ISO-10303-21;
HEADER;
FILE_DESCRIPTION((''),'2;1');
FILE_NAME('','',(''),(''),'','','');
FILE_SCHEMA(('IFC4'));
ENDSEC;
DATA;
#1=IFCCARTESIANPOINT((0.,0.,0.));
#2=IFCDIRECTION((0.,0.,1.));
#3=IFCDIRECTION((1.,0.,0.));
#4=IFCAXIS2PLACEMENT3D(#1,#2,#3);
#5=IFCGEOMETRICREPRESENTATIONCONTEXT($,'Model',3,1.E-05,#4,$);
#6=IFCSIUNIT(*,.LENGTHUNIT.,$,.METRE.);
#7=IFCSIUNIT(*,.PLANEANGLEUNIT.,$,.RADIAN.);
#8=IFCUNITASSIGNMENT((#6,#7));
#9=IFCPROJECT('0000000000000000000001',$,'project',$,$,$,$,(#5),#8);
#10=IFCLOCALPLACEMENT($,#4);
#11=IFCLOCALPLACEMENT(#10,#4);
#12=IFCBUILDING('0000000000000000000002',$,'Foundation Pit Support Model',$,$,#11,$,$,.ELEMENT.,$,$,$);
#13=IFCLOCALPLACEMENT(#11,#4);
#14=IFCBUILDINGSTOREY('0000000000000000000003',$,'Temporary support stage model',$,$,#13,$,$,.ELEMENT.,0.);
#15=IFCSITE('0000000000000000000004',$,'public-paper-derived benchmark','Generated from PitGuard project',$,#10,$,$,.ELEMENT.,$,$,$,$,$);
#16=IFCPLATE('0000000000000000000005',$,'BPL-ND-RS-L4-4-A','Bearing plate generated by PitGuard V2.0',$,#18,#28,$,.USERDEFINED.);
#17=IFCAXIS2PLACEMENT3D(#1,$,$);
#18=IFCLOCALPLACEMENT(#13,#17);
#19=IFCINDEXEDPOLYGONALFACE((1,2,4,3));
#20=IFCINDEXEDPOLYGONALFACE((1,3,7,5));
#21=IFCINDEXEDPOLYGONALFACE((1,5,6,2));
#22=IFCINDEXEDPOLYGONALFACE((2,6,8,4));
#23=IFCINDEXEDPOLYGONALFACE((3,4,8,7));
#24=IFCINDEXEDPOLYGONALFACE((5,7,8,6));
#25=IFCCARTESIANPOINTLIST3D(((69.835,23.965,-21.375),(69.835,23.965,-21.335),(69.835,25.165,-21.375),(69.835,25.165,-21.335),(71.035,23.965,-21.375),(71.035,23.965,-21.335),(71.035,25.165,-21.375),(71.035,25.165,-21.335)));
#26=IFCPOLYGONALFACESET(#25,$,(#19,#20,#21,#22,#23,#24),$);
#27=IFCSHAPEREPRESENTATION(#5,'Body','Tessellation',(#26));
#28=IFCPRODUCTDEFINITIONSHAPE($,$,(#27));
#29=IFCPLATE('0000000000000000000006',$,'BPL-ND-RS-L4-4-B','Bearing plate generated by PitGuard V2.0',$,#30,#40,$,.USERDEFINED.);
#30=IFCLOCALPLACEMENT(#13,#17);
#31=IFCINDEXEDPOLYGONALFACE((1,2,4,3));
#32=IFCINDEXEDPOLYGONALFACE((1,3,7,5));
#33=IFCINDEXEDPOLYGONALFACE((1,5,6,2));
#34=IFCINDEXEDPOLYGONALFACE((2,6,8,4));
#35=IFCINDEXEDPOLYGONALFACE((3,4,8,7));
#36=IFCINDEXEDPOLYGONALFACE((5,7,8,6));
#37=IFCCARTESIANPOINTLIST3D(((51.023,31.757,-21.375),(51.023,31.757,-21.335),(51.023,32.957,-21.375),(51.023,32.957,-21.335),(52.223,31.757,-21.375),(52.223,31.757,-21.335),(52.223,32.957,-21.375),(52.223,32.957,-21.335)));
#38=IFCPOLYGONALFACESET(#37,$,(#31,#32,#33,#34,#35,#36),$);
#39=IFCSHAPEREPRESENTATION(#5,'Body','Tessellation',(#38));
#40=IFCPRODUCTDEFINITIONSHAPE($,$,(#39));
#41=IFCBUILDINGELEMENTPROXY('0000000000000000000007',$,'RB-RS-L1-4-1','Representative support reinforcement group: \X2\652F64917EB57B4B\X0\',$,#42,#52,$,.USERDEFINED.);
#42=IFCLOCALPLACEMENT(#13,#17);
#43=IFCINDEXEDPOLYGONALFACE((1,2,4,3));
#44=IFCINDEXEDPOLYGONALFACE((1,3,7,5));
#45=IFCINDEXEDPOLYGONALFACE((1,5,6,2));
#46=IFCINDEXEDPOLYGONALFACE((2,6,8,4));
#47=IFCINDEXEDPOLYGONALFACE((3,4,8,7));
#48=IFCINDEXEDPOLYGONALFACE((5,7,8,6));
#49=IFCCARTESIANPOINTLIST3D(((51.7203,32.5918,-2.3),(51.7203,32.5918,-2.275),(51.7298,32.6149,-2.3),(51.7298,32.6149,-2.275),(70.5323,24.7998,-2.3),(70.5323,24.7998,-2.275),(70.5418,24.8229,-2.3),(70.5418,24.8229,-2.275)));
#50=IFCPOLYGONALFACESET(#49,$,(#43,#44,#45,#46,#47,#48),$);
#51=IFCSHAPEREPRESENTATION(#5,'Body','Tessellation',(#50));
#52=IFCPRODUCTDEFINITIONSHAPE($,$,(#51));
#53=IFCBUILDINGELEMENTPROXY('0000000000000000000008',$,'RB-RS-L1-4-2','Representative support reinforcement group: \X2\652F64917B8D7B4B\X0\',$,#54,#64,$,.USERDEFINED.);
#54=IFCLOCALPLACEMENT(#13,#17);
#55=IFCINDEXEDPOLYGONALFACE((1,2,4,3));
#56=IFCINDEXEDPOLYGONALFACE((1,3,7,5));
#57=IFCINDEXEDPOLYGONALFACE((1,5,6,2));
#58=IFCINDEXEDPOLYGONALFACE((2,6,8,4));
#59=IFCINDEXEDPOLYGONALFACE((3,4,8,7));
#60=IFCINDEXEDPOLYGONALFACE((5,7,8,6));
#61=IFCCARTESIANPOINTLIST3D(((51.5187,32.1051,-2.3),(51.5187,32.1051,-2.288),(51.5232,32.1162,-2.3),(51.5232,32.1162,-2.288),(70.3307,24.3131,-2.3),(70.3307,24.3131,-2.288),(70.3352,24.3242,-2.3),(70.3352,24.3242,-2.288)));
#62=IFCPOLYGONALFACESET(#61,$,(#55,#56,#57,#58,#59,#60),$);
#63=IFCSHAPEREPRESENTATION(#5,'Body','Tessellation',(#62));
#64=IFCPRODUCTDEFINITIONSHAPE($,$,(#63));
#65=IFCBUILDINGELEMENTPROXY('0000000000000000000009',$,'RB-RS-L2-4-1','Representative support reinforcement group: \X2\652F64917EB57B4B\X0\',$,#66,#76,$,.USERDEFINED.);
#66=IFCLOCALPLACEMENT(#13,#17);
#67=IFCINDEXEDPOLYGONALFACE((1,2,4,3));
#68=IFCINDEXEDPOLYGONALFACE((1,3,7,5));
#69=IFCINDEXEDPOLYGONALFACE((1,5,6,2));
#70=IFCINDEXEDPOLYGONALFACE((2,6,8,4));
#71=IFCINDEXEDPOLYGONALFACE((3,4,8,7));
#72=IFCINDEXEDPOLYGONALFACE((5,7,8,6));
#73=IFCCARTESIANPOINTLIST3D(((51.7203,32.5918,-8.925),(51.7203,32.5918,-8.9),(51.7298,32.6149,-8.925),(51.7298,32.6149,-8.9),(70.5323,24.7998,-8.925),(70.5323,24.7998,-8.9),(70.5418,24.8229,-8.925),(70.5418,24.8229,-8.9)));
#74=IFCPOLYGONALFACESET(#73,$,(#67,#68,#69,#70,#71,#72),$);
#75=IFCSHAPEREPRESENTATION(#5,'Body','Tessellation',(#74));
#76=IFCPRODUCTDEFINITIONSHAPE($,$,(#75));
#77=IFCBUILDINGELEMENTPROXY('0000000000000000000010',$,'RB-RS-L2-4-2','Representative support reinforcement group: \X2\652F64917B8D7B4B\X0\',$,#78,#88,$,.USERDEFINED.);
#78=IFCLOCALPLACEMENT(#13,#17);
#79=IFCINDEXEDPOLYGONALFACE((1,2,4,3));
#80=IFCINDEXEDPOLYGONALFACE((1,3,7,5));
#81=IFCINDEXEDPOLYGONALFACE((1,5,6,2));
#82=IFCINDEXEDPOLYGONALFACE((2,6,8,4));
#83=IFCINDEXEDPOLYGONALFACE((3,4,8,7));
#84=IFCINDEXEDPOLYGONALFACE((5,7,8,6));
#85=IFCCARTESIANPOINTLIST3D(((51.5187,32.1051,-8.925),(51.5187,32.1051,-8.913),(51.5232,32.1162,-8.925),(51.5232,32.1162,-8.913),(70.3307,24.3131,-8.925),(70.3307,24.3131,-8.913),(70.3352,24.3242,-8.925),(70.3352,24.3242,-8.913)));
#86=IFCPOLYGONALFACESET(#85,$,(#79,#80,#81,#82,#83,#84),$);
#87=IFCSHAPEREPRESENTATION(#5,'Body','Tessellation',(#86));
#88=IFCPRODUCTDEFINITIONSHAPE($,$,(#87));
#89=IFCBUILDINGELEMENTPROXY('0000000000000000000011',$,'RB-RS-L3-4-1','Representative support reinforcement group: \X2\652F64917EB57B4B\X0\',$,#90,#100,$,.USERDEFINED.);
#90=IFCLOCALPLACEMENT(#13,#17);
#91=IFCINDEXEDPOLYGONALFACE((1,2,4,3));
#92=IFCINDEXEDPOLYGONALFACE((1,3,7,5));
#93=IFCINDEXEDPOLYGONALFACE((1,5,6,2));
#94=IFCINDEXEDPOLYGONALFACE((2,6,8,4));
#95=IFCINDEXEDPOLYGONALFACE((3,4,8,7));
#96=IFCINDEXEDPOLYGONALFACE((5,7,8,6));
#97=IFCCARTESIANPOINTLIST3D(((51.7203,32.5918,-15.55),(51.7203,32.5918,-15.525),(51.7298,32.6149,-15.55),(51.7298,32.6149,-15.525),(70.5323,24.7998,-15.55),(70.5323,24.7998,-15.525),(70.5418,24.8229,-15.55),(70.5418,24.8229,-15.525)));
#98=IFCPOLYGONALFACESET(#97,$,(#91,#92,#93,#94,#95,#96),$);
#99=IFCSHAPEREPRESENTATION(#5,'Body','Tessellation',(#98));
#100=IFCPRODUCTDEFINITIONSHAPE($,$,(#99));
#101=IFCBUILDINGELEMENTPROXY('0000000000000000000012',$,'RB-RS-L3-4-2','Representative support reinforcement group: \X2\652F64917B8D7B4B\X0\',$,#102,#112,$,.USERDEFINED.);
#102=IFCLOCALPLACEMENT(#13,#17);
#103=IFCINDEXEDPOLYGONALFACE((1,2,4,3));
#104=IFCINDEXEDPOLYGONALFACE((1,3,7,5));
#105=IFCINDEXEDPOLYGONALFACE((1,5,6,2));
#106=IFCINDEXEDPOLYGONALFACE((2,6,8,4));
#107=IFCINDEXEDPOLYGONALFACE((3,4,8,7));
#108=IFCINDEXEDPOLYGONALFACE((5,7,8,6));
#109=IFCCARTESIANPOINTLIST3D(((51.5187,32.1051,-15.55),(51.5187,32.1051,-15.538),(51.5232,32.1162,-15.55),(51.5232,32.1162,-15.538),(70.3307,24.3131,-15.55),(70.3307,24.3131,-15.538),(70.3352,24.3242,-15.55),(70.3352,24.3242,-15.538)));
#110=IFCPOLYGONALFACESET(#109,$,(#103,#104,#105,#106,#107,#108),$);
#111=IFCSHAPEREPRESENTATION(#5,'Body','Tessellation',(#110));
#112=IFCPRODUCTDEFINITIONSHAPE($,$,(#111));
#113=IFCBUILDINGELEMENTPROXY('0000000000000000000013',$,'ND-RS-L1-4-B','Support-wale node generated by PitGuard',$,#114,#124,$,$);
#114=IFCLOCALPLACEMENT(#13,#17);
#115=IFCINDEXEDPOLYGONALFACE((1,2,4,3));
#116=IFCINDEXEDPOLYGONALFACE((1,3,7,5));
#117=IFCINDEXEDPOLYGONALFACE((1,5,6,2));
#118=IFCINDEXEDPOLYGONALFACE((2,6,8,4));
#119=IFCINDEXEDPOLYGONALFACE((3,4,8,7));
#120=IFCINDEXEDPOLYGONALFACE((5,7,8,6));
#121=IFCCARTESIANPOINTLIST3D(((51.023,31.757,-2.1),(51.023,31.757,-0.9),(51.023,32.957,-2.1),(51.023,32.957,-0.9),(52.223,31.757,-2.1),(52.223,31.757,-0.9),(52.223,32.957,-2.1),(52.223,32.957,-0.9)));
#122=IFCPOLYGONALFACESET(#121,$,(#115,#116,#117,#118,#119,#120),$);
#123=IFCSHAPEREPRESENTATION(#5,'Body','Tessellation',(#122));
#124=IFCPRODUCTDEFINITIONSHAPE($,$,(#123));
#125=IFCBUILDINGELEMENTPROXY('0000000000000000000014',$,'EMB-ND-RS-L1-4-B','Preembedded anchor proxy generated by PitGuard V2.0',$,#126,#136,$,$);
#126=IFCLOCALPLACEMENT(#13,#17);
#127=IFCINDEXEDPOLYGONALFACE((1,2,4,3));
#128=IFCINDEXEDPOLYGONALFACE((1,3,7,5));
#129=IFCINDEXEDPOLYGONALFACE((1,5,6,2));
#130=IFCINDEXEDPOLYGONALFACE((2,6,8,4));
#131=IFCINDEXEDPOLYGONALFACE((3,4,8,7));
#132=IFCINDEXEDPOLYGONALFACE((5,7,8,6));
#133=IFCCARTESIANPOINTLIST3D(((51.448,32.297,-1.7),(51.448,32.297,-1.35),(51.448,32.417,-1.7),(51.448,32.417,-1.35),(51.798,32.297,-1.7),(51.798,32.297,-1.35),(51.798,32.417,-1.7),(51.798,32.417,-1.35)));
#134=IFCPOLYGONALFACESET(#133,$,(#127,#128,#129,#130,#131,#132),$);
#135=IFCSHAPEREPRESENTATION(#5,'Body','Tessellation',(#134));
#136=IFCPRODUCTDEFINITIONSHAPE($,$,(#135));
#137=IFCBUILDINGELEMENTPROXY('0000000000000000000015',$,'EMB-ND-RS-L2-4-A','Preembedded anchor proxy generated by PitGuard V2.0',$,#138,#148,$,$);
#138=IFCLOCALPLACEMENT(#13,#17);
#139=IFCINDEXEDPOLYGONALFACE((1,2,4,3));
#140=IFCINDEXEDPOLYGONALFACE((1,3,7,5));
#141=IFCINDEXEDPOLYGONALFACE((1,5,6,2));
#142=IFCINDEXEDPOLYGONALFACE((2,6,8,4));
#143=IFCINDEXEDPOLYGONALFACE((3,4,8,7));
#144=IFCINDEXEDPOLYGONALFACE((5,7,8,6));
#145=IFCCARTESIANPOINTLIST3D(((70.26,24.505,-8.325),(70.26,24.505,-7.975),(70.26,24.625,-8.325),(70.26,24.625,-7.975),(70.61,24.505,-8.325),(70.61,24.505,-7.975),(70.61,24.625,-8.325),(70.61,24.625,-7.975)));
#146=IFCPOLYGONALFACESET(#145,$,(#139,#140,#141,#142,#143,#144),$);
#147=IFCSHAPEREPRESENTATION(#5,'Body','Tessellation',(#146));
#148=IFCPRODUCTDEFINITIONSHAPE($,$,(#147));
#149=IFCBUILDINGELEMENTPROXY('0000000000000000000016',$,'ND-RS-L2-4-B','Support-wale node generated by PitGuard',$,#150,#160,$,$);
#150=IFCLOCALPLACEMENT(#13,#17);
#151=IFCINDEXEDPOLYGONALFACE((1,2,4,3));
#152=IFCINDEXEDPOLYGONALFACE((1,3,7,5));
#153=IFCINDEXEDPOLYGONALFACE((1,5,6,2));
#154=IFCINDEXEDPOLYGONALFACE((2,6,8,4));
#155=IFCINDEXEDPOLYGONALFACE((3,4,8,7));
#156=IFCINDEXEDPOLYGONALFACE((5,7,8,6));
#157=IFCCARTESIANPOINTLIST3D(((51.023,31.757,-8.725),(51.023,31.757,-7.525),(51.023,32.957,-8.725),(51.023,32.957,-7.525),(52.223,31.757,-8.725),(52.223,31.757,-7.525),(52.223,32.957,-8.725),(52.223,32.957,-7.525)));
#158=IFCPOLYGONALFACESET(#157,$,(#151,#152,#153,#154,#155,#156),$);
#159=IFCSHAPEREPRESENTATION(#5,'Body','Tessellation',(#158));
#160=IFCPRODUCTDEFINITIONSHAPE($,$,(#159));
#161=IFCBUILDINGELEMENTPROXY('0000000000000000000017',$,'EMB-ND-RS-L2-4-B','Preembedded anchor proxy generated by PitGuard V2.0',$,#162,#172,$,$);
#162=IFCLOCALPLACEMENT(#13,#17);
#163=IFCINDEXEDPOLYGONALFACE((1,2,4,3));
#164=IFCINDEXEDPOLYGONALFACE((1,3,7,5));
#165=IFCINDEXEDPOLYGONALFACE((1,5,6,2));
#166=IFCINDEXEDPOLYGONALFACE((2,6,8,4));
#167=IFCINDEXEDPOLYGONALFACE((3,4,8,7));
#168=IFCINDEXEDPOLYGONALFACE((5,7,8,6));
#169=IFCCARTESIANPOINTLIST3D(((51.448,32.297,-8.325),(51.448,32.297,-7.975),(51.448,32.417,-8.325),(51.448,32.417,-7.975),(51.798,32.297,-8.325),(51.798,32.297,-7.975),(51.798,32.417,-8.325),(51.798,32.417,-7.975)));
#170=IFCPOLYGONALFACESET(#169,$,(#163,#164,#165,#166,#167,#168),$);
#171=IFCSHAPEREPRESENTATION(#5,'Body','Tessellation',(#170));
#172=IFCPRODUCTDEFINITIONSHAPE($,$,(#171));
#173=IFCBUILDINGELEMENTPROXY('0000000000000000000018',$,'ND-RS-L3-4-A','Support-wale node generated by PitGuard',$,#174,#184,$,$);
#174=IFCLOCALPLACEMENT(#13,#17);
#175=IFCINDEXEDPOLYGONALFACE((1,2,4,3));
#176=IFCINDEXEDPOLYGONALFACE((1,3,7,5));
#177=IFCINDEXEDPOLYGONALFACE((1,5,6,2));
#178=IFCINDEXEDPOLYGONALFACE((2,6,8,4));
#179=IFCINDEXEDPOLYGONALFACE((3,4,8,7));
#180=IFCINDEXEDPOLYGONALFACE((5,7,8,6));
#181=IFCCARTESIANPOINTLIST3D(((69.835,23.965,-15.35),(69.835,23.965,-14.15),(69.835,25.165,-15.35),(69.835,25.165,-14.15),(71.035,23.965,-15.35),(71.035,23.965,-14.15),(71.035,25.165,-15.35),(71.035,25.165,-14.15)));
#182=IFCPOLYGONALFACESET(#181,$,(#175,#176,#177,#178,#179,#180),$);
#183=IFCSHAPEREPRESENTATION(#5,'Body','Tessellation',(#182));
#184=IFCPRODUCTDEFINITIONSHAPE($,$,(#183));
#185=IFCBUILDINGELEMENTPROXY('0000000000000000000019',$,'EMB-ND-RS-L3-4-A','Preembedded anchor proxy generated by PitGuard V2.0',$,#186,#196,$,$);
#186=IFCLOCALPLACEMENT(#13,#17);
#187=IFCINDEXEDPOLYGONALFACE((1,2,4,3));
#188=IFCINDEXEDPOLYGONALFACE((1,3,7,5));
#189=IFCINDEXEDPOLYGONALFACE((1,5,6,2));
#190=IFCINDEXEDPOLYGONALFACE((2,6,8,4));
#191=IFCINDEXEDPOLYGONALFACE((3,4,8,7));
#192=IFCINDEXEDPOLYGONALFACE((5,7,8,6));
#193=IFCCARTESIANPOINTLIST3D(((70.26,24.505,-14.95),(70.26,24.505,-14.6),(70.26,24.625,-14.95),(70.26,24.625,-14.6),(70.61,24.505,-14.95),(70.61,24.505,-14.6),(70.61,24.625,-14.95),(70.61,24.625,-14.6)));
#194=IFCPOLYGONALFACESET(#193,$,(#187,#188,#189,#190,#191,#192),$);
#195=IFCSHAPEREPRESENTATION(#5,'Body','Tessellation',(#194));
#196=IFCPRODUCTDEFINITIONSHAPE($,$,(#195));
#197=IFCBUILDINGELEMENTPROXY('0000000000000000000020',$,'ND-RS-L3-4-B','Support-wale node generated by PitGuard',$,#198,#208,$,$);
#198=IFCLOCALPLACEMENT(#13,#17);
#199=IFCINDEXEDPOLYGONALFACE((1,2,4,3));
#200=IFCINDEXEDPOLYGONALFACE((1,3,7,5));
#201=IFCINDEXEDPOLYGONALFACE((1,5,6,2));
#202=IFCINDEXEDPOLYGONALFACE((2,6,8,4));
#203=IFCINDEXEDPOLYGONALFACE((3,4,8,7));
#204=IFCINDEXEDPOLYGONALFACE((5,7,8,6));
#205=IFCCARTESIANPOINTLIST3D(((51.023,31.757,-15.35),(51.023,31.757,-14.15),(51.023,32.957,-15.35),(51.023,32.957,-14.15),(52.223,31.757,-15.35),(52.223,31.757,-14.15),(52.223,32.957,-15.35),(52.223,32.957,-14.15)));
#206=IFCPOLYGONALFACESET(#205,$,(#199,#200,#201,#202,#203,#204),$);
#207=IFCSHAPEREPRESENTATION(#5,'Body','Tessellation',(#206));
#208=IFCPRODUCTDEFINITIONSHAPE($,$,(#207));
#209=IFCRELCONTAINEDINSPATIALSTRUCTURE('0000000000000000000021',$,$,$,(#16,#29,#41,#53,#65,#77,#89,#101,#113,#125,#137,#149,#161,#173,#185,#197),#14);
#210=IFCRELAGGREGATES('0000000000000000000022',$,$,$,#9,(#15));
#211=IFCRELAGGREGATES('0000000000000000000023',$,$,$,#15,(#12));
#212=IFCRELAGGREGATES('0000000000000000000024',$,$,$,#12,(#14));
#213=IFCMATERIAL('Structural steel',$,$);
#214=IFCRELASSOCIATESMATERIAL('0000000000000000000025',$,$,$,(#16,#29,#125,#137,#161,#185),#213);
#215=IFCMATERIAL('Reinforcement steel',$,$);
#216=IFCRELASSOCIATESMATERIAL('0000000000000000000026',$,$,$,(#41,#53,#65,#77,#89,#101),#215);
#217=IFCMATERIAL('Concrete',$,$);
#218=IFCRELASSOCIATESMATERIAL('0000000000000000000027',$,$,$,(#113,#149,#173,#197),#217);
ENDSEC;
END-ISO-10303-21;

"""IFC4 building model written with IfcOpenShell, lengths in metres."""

from ifc_helpers import new_model, si_unit, frame, origin_with_axes, origin_2d, place, context, project, spatial, rectangle, extrude, material, element, save


model = new_model("IFC4")

# Units and contexts
model_context = context("Model", 3, precision=1e-05, world=origin_with_axes())
ifc_project = project(units=[si_unit("LENGTHUNIT", "METRE"), si_unit("PLANEANGLEUNIT", "RADIAN")], contexts=[model_context])

# Site, building, storey
site_placement = place(None, origin_with_axes())
site = spatial("IfcSite", under=ifc_project, at=site_placement, Name="public-paper-derived benchmark", Description="Generated from PitGuard project", CompositionType="ELEMENT")
building_placement = place(site_placement, origin_with_axes())
building = spatial("IfcBuilding", under=site, at=building_placement, Name="Foundation Pit Support Model", CompositionType="ELEMENT")
storey_placement = place(building_placement, origin_with_axes())
storey = spatial("IfcBuildingStorey", under=building, at=storey_placement, Name="Temporary support stage model", CompositionType="ELEMENT", Elevation=0.0)

# Shared definitions
ifc_material_1 = material(Name="Concrete")

# Plates
ifc_material_2 = material(Name="Structural steel")
for number, where, z_axis, x_axis, name in (
    (1, (70.435, 24.565, -21.375), (0.0, 0.0, 1.0), (1.0, 0.0, 0.0), "BPL-ND-RS-L4-4-A"),
    (2, (51.623, 32.357, -21.375), (0.0, 0.0, 1.0), (1.0, 0.0, 0.0), "BPL-ND-RS-L4-4-B"),
):
    element("IfcPlate", number, at=place(storey_placement, frame(where, z_axis=z_axis, x_axis=x_axis)), inside=storey, material=ifc_material_2, Name=name, Description="Bearing plate generated by PitGuard V2.0", PredefinedType="USERDEFINED", context=model_context, shape_type="SweptSolid", body=[
        extrude(rectangle(XDim=1.2, YDim=1.2, at=origin_2d()), origin_with_axes(), (0.0, 0.0, 1.0), 0.04),
    ])

# Building element proxies
ifc_material_3 = material(Name="Reinforcement steel")
proxy_1_placement = place(storey_placement, frame((61.131, 28.7074, -2.3), z_axis=(0.0, 0.0, 1.0), x_axis=(-0.923883, 0.382676, 0.0)))
element("IfcBuildingElementProxy", 3, at=proxy_1_placement, inside=storey, material=ifc_material_3, Name="RB-RS-L1-4-1", Description="Representative support reinforcement group: 支撑纵筋", PredefinedType="USERDEFINED", context=model_context, shape_type="SweptSolid", body=[
    extrude(rectangle(XDim=20.3619, YDim=0.025, at=origin_2d()), origin_with_axes(), (0.0, 0.0, 1.0), 0.025),
])
proxy_2_placement = place(storey_placement, frame((60.927, 28.2146, -2.3), z_axis=(0.0, 0.0, 1.0), x_axis=(-0.923883, 0.382676, 0.0)))
element("IfcBuildingElementProxy", 4, at=proxy_2_placement, inside=storey, material=ifc_material_3, Name="RB-RS-L1-4-2", Description="Representative support reinforcement group: 支撑箍筋", PredefinedType="USERDEFINED", context=model_context, shape_type="SweptSolid", body=[
    extrude(rectangle(XDim=20.3619, YDim=0.012, at=origin_2d()), origin_with_axes(), (0.0, 0.0, 1.0), 0.012),
])
proxy_3_placement = place(storey_placement, frame((61.131, 28.7074, -8.925), z_axis=(0.0, 0.0, 1.0), x_axis=(-0.923883, 0.382676, 0.0)))
element("IfcBuildingElementProxy", 5, at=proxy_3_placement, inside=storey, material=ifc_material_3, Name="RB-RS-L2-4-1", Description="Representative support reinforcement group: 支撑纵筋", PredefinedType="USERDEFINED", context=model_context, shape_type="SweptSolid", body=[
    extrude(rectangle(XDim=20.3619, YDim=0.025, at=origin_2d()), origin_with_axes(), (0.0, 0.0, 1.0), 0.025),
])
proxy_4_placement = place(storey_placement, frame((60.927, 28.2146, -8.925), z_axis=(0.0, 0.0, 1.0), x_axis=(-0.923883, 0.382676, 0.0)))
element("IfcBuildingElementProxy", 6, at=proxy_4_placement, inside=storey, material=ifc_material_3, Name="RB-RS-L2-4-2", Description="Representative support reinforcement group: 支撑箍筋", PredefinedType="USERDEFINED", context=model_context, shape_type="SweptSolid", body=[
    extrude(rectangle(XDim=20.3619, YDim=0.012, at=origin_2d()), origin_with_axes(), (0.0, 0.0, 1.0), 0.012),
])
proxy_5_placement = place(storey_placement, frame((61.131, 28.7074, -15.55), z_axis=(0.0, 0.0, 1.0), x_axis=(-0.923883, 0.382676, 0.0)))
element("IfcBuildingElementProxy", 7, at=proxy_5_placement, inside=storey, material=ifc_material_3, Name="RB-RS-L3-4-1", Description="Representative support reinforcement group: 支撑纵筋", PredefinedType="USERDEFINED", context=model_context, shape_type="SweptSolid", body=[
    extrude(rectangle(XDim=20.3619, YDim=0.025, at=origin_2d()), origin_with_axes(), (0.0, 0.0, 1.0), 0.025),
])
proxy_6_placement = place(storey_placement, frame((60.927, 28.2146, -15.55), z_axis=(0.0, 0.0, 1.0), x_axis=(-0.923883, 0.382676, 0.0)))
element("IfcBuildingElementProxy", 8, at=proxy_6_placement, inside=storey, material=ifc_material_3, Name="RB-RS-L3-4-2", Description="Representative support reinforcement group: 支撑箍筋", PredefinedType="USERDEFINED", context=model_context, shape_type="SweptSolid", body=[
    extrude(rectangle(XDim=20.3619, YDim=0.012, at=origin_2d()), origin_with_axes(), (0.0, 0.0, 1.0), 0.012),
])
proxy_7_placement = place(storey_placement, frame((51.623, 32.357, -2.1), z_axis=(0.0, 0.0, 1.0), x_axis=(1.0, 0.0, 0.0)))
element("IfcBuildingElementProxy", 9, at=proxy_7_placement, inside=storey, material=ifc_material_1, Name="ND-RS-L1-4-B", Description="Support-wale node generated by PitGuard", context=model_context, shape_type="SweptSolid", body=[
    extrude(rectangle(XDim=1.2, YDim=1.2, at=origin_2d()), origin_with_axes(), (0.0, 0.0, 1.0), 1.2),
])
for number, where, z_axis, x_axis, name in (
    (10, (51.623, 32.357, -1.7), (0.0, 0.0, 1.0), (1.0, 0.0, 0.0), "EMB-ND-RS-L1-4-B"),
    (11, (70.435, 24.565, -8.325), (0.0, 0.0, 1.0), (1.0, 0.0, 0.0), "EMB-ND-RS-L2-4-A"),
):
    element("IfcBuildingElementProxy", number, at=place(storey_placement, frame(where, z_axis=z_axis, x_axis=x_axis)), inside=storey, material=ifc_material_2, Name=name, Description="Preembedded anchor proxy generated by PitGuard V2.0", context=model_context, shape_type="SweptSolid", body=[
        extrude(rectangle(XDim=0.35, YDim=0.12, at=origin_2d()), origin_with_axes(), (0.0, 0.0, 1.0), 0.35),
    ])
proxy_8_placement = place(storey_placement, frame((51.623, 32.357, -8.725), z_axis=(0.0, 0.0, 1.0), x_axis=(1.0, 0.0, 0.0)))
element("IfcBuildingElementProxy", 12, at=proxy_8_placement, inside=storey, material=ifc_material_1, Name="ND-RS-L2-4-B", Description="Support-wale node generated by PitGuard", context=model_context, shape_type="SweptSolid", body=[
    extrude(rectangle(XDim=1.2, YDim=1.2, at=origin_2d()), origin_with_axes(), (0.0, 0.0, 1.0), 1.2),
])
proxy_9_placement = place(storey_placement, frame((51.623, 32.357, -8.325), z_axis=(0.0, 0.0, 1.0), x_axis=(1.0, 0.0, 0.0)))
element("IfcBuildingElementProxy", 13, at=proxy_9_placement, inside=storey, material=ifc_material_2, Name="EMB-ND-RS-L2-4-B", Description="Preembedded anchor proxy generated by PitGuard V2.0", context=model_context, shape_type="SweptSolid", body=[
    extrude(rectangle(XDim=0.35, YDim=0.12, at=origin_2d()), origin_with_axes(), (0.0, 0.0, 1.0), 0.35),
])
proxy_10_placement = place(storey_placement, frame((70.435, 24.565, -15.35), z_axis=(0.0, 0.0, 1.0), x_axis=(1.0, 0.0, 0.0)))
element("IfcBuildingElementProxy", 14, at=proxy_10_placement, inside=storey, material=ifc_material_1, Name="ND-RS-L3-4-A", Description="Support-wale node generated by PitGuard", context=model_context, shape_type="SweptSolid", body=[
    extrude(rectangle(XDim=1.2, YDim=1.2, at=origin_2d()), origin_with_axes(), (0.0, 0.0, 1.0), 1.2),
])
proxy_11_placement = place(storey_placement, frame((70.435, 24.565, -14.95), z_axis=(0.0, 0.0, 1.0), x_axis=(1.0, 0.0, 0.0)))
element("IfcBuildingElementProxy", 15, at=proxy_11_placement, inside=storey, material=ifc_material_2, Name="EMB-ND-RS-L3-4-A", Description="Preembedded anchor proxy generated by PitGuard V2.0", context=model_context, shape_type="SweptSolid", body=[
    extrude(rectangle(XDim=0.35, YDim=0.12, at=origin_2d()), origin_with_axes(), (0.0, 0.0, 1.0), 0.35),
])
proxy_12_placement = place(storey_placement, frame((51.623, 32.357, -15.35), z_axis=(0.0, 0.0, 1.0), x_axis=(1.0, 0.0, 0.0)))
element("IfcBuildingElementProxy", 16, at=proxy_12_placement, inside=storey, material=ifc_material_1, Name="ND-RS-L3-4-B", Description="Support-wale node generated by PitGuard", context=model_context, shape_type="SweptSolid", body=[
    extrude(rectangle(XDim=1.2, YDim=1.2, at=origin_2d()), origin_with_axes(), (0.0, 0.0, 1.0), 1.2),
])

save(model, "model.ifc")
